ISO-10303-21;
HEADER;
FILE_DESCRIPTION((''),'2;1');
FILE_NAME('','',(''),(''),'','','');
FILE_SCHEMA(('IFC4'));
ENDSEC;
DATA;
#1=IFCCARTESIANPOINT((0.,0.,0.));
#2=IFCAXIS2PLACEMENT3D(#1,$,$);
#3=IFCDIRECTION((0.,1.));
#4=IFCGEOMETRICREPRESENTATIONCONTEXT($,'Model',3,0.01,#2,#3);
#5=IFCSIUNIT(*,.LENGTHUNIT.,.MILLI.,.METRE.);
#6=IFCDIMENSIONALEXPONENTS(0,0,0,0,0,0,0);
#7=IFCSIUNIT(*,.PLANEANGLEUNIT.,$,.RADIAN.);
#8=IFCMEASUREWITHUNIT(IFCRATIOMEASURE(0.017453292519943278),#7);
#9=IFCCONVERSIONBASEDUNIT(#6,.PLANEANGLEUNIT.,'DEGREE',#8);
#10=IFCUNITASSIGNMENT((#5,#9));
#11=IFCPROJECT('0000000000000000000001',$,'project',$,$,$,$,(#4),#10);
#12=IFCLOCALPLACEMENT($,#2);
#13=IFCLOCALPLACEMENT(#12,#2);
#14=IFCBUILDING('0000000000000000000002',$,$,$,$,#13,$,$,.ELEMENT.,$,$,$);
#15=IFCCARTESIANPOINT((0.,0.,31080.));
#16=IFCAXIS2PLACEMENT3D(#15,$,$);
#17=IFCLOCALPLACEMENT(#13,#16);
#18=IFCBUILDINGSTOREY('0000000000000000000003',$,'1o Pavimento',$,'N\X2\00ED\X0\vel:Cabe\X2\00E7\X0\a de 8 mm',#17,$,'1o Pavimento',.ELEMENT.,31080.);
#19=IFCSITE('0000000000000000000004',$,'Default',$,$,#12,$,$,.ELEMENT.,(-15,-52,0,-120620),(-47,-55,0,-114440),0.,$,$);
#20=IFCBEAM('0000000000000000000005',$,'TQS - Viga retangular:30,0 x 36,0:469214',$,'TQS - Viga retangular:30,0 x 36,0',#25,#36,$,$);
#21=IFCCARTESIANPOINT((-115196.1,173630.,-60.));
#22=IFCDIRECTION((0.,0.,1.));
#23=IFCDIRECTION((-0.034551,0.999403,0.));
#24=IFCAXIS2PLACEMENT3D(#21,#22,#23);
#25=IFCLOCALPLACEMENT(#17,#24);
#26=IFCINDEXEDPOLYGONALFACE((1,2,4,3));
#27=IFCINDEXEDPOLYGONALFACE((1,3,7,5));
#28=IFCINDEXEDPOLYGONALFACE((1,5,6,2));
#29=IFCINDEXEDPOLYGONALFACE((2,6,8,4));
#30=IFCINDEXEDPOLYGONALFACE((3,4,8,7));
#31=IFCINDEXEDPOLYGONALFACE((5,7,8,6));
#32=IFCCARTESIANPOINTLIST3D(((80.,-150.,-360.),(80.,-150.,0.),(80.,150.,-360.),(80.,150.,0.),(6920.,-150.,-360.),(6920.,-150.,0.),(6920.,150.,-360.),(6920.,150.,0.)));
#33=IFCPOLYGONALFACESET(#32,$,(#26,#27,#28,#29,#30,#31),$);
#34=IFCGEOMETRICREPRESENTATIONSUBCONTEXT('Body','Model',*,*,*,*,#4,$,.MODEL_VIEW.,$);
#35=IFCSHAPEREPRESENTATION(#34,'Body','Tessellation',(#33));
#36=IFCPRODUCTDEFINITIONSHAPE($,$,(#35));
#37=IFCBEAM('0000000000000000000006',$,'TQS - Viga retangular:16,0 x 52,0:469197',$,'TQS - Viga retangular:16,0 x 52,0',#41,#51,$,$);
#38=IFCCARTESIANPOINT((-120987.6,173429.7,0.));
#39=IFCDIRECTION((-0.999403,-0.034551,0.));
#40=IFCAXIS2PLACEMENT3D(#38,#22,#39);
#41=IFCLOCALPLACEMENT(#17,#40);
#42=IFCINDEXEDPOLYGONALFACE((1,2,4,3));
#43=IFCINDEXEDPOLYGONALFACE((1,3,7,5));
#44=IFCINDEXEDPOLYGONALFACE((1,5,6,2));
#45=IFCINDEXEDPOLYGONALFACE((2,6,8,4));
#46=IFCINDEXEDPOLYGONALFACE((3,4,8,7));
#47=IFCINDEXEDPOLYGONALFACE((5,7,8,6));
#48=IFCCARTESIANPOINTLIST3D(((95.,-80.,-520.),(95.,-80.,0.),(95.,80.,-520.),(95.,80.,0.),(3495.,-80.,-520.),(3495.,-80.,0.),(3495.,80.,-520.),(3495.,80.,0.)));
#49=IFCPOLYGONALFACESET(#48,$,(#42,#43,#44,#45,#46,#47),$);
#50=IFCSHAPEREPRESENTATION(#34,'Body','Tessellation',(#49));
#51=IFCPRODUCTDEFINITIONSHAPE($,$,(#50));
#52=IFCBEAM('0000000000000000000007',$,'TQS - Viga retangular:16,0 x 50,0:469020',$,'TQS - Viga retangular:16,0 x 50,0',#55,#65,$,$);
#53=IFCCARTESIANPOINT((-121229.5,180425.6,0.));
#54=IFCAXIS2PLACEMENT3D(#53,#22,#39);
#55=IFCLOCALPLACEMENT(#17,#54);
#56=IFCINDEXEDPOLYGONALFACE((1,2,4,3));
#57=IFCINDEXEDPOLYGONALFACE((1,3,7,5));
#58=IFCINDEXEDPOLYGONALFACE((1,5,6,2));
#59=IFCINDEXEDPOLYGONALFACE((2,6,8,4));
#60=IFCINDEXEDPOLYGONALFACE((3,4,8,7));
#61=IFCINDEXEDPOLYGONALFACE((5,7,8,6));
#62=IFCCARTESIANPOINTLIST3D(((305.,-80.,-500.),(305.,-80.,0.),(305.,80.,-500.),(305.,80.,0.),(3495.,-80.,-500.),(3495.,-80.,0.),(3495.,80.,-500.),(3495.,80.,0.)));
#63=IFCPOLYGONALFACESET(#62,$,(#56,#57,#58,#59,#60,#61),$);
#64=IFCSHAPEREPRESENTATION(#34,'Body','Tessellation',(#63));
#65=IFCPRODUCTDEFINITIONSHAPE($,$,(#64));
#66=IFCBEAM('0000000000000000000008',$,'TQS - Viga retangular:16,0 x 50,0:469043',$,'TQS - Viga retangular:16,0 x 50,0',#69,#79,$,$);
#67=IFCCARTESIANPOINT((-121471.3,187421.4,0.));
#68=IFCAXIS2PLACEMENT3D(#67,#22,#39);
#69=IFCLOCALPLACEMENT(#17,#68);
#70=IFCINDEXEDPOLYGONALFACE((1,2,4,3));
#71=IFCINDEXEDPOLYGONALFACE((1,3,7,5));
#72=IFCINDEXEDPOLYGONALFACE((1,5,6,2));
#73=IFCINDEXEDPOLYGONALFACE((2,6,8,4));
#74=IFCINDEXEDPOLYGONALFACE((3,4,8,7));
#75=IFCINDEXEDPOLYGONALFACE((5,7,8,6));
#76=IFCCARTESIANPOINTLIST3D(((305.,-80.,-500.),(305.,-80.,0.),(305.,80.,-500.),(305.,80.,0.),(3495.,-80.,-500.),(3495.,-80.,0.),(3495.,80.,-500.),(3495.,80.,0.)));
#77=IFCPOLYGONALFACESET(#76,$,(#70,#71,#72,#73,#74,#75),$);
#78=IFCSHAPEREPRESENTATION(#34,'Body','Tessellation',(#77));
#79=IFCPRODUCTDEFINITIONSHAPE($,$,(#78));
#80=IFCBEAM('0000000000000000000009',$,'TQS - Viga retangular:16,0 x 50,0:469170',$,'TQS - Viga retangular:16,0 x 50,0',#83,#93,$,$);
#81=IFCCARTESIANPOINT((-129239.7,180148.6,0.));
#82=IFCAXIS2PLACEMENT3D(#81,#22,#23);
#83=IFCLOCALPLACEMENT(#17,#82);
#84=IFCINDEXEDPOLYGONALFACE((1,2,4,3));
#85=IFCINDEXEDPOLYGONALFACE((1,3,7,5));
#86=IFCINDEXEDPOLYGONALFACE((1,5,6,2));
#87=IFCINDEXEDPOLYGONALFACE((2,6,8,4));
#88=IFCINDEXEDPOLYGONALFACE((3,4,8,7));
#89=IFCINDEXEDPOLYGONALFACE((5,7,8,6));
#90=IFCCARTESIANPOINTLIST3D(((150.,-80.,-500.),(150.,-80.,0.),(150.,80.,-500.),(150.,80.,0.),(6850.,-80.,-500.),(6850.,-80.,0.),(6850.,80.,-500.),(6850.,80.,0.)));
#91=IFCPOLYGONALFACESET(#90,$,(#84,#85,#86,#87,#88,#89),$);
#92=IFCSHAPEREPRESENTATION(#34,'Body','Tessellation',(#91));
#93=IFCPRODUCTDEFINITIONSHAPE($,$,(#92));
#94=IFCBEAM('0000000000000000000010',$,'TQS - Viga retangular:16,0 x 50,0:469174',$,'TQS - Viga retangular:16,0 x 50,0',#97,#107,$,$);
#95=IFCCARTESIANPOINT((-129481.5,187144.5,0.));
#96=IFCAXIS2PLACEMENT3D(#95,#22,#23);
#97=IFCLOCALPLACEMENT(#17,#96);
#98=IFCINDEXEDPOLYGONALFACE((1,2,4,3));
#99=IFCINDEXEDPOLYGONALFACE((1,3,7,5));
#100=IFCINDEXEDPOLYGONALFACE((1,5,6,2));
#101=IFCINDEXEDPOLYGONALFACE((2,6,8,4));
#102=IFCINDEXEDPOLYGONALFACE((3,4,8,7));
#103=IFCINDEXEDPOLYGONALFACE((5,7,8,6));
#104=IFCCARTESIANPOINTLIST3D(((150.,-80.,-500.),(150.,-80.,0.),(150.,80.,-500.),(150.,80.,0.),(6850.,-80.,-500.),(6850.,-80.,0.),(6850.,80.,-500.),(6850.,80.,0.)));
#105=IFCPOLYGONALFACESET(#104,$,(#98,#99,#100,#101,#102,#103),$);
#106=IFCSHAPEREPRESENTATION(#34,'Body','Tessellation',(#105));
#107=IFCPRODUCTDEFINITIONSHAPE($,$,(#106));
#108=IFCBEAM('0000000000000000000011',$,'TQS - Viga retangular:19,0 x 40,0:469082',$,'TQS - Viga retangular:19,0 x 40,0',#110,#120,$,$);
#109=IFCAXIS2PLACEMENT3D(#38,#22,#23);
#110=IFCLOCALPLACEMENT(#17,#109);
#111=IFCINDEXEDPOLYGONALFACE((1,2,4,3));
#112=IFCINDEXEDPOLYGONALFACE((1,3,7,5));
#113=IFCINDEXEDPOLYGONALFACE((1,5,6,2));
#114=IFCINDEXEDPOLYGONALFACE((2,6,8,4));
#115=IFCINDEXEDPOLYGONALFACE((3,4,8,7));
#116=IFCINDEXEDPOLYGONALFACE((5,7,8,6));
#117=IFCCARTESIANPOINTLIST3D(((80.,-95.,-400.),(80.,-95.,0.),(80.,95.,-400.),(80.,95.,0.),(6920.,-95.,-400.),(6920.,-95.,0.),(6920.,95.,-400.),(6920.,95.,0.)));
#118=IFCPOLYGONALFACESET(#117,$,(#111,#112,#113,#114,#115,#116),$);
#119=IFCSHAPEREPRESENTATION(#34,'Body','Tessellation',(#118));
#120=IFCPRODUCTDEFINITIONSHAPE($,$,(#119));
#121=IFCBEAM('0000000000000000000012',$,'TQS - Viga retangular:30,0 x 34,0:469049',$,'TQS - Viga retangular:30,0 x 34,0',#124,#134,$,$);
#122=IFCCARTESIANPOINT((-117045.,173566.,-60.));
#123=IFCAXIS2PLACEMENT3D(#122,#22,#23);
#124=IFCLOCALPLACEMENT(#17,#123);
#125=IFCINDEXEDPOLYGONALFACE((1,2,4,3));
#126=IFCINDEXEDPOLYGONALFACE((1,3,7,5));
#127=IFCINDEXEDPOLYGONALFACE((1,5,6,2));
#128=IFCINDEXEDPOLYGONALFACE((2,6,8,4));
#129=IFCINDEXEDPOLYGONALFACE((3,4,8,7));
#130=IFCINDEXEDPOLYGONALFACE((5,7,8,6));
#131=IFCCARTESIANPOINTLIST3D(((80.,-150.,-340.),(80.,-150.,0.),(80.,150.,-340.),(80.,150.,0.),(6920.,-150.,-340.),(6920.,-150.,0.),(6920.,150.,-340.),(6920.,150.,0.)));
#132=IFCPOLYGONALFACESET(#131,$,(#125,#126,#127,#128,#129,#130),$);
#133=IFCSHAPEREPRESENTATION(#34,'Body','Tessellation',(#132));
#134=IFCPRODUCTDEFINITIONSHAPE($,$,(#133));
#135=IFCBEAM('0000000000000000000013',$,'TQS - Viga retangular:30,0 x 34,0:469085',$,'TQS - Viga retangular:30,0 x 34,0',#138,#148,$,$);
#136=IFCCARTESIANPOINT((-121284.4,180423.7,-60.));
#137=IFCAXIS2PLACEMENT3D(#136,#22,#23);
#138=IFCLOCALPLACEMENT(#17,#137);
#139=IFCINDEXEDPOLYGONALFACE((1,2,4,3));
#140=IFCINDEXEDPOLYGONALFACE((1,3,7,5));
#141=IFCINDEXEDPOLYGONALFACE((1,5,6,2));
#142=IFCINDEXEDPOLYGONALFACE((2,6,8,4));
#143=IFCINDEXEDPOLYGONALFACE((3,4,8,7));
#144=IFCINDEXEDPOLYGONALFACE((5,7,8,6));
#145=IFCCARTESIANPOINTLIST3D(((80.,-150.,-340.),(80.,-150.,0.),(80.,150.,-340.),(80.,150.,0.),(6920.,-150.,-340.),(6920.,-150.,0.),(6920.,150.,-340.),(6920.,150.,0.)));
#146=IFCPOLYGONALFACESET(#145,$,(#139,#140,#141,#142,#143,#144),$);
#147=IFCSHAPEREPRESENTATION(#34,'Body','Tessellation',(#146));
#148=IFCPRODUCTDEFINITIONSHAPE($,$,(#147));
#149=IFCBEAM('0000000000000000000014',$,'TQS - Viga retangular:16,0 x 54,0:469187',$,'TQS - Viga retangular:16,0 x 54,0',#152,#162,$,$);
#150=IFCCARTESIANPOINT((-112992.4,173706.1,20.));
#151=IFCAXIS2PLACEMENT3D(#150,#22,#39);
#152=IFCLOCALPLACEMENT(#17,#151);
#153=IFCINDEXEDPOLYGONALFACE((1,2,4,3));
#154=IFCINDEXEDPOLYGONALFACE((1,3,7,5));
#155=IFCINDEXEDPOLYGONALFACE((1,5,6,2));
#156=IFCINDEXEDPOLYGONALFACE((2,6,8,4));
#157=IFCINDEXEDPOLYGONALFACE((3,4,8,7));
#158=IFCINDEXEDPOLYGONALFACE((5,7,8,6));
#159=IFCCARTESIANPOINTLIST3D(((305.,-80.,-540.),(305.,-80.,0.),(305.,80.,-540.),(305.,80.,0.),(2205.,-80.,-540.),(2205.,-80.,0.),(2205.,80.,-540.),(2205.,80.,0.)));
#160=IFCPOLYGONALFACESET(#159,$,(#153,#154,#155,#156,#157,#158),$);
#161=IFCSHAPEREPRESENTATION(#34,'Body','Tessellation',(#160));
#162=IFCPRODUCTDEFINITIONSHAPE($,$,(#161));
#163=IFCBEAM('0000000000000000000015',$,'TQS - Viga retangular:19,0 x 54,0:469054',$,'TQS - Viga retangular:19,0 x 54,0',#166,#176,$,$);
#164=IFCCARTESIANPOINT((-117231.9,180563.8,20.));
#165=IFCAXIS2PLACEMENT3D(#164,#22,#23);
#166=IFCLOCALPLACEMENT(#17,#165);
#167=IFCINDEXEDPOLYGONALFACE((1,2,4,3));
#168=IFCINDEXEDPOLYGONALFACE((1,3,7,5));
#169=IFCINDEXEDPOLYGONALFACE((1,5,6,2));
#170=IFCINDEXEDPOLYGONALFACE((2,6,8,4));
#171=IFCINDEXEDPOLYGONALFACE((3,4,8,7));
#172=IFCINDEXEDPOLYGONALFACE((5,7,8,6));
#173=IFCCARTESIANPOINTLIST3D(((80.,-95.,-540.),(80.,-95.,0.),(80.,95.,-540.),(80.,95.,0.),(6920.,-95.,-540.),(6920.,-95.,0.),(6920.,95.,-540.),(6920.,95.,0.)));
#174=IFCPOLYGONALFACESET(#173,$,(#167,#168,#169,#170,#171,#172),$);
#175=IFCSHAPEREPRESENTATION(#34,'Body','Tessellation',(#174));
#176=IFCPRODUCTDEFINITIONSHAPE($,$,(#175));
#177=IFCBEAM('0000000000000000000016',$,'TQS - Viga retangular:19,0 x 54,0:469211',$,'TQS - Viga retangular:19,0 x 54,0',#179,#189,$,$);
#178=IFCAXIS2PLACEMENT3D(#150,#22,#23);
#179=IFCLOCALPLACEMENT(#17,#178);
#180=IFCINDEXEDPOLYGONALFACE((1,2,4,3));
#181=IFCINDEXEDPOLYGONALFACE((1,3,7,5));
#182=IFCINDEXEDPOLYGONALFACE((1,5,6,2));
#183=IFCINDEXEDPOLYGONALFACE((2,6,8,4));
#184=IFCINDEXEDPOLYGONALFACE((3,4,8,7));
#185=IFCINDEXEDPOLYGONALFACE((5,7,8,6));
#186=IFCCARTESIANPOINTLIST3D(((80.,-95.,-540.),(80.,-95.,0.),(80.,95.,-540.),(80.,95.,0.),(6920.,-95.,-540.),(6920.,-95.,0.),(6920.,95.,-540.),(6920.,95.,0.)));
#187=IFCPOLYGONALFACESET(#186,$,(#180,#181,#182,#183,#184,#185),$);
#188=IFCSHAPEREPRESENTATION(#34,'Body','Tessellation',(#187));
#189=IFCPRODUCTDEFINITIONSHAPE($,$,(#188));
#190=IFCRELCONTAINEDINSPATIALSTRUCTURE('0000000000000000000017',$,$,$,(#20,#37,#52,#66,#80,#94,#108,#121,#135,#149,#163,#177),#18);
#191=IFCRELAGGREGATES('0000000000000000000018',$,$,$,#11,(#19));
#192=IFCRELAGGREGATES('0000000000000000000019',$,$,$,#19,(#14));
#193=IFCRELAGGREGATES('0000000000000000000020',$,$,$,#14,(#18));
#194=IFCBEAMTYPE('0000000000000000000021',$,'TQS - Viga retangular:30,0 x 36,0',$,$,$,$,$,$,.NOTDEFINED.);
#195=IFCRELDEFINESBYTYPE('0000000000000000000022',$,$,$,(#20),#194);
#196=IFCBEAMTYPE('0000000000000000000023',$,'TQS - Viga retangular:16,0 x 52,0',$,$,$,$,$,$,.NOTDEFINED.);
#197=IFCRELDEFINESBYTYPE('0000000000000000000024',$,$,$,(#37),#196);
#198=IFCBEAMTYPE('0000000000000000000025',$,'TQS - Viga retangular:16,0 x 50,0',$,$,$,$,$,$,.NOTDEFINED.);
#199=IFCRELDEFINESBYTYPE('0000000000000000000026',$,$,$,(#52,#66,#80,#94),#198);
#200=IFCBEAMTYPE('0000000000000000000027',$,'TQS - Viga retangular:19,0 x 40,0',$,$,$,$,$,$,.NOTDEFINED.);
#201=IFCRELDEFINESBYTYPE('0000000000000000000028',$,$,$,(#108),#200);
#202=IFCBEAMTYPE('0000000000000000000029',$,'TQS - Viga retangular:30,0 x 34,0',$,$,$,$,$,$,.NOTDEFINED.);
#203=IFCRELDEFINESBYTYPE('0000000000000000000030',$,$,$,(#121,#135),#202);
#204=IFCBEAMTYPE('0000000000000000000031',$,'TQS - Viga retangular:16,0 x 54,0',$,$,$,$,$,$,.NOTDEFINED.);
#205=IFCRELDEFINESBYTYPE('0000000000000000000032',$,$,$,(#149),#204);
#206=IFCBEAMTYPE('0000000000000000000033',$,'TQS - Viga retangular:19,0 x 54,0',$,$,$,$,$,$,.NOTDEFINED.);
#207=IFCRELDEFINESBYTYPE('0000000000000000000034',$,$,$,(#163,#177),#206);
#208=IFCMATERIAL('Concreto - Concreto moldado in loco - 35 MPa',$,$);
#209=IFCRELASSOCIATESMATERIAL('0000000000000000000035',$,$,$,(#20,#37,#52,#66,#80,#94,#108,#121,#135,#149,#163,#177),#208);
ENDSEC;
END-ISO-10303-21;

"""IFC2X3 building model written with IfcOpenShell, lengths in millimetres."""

from ifc_helpers import new_model, entity, si_unit, converted_unit, direction, frame, frame_2d, origin, place, context, subcontext, project, spatial, rectangle, extrude, material, type_object, element, save


model = new_model("IFC2X3")

# Units and contexts
model_context = context("Model", 3, precision=0.01, world=origin(), true_north=direction((0.0, 1.0)))
body_context = subcontext(model_context, "Body", "Model", "MODEL_VIEW")
ifc_project = project(units=[si_unit("LENGTHUNIT", "METRE", prefix="MILLI"), converted_unit("PLANEANGLEUNIT", "DEGREE", entity("IfcRatioMeasure", 0.017453292519943278), si_unit("PLANEANGLEUNIT", "RADIAN"), dimensions=[0, 0, 0, 0, 0, 0, 0])], contexts=[model_context])

# Site, building, storey
site_placement = place(None, origin())
site = spatial("IfcSite", under=ifc_project, at=site_placement, Name="Default", CompositionType="ELEMENT", RefLatitude=(-15, -52, 0, -120620), RefLongitude=(-47, -55, 0, -114440), RefElevation=0.0)
building_placement = place(site_placement, origin())
building = spatial("IfcBuilding", under=site, at=building_placement, CompositionType="ELEMENT")
storey_placement = place(building_placement, frame((0.0, 0.0, 31080.0)))
storey = spatial("IfcBuildingStorey", under=building, at=storey_placement, Name="1o Pavimento", ObjectType="Nível:Cabeça de 8 mm", LongName="1o Pavimento", CompositionType="ELEMENT", Elevation=31080.0)

# Beams
ifc_material_1 = material(Name="Concreto - Concreto moldado in loco - 35 MPa")
beam_type_1 = type_object("IfcBeamType", Name="TQS - Viga retangular:30,0 x 36,0", PredefinedType="NOTDEFINED")
beam_1_placement = place(storey_placement, frame((-115196.1, 173630.0, -60.0), z_axis=(0.0, 0.0, 1.0), x_axis=(-0.034551, 0.999403, 0.0)))
element("IfcBeam", 1, at=beam_1_placement, inside=storey, type_object=beam_type_1, material=ifc_material_1, Name="TQS - Viga retangular:30,0 x 36,0:469214", ObjectType="TQS - Viga retangular:30,0 x 36,0", context=body_context, shape_type="SweptSolid", body=[
    extrude(rectangle(XDim=360.0, YDim=300.0, at=frame_2d((0.0, 0.0), x_axis=(1.0, 0.0))), frame((80.0, 0.0, -180.0), z_axis=(1.0, 0.0, 0.0), x_axis=(0.0, 0.0, -1.0)), (0.0, 0.0, 1.0), 6840.0),
])
beam_type_2 = type_object("IfcBeamType", Name="TQS - Viga retangular:16,0 x 52,0", PredefinedType="NOTDEFINED")
beam_2_placement = place(storey_placement, frame((-120987.6, 173429.7, 0.0), z_axis=(0.0, 0.0, 1.0), x_axis=(-0.999403, -0.034551, 0.0)))
element("IfcBeam", 2, at=beam_2_placement, inside=storey, type_object=beam_type_2, material=ifc_material_1, Name="TQS - Viga retangular:16,0 x 52,0:469197", ObjectType="TQS - Viga retangular:16,0 x 52,0", context=body_context, shape_type="SweptSolid", body=[
    extrude(rectangle(XDim=520.0, YDim=160.0, at=frame_2d((0.0, 0.0), x_axis=(1.0, 0.0))), frame((95.0, 0.0, -260.0), z_axis=(1.0, 0.0, 0.0), x_axis=(0.0, 0.0, -1.0)), (0.0, 0.0, 1.0), 3400.0),
])
beam_type_3 = type_object("IfcBeamType", Name="TQS - Viga retangular:16,0 x 50,0", PredefinedType="NOTDEFINED")
beam_3_placement = place(storey_placement, frame((-121229.5, 180425.6, 0.0), z_axis=(0.0, 0.0, 1.0), x_axis=(-0.999403, -0.034551, 0.0)))
element("IfcBeam", 3, at=beam_3_placement, inside=storey, type_object=beam_type_3, material=ifc_material_1, Name="TQS - Viga retangular:16,0 x 50,0:469020", ObjectType="TQS - Viga retangular:16,0 x 50,0", context=body_context, shape_type="SweptSolid", body=[
    extrude(rectangle(XDim=500.0, YDim=160.0, at=frame_2d((0.0, 0.0), x_axis=(1.0, 0.0))), frame((305.0, 0.0, -250.0), z_axis=(1.0, 0.0, 0.0), x_axis=(0.0, 0.0, -1.0)), (0.0, 0.0, 1.0), 3190.0),
])
beam_4_placement = place(storey_placement, frame((-121471.3, 187421.4, 0.0), z_axis=(0.0, 0.0, 1.0), x_axis=(-0.999403, -0.034551, 0.0)))
element("IfcBeam", 4, at=beam_4_placement, inside=storey, type_object=beam_type_3, material=ifc_material_1, Name="TQS - Viga retangular:16,0 x 50,0:469043", ObjectType="TQS - Viga retangular:16,0 x 50,0", context=body_context, shape_type="SweptSolid", body=[
    extrude(rectangle(XDim=500.0, YDim=160.0, at=frame_2d((0.0, 0.0), x_axis=(1.0, 0.0))), frame((305.0, 0.0, -250.0), z_axis=(1.0, 0.0, 0.0), x_axis=(0.0, 0.0, -1.0)), (0.0, 0.0, 1.0), 3190.0),
])
beam_5_placement = place(storey_placement, frame((-129239.7, 180148.6, 0.0), z_axis=(0.0, 0.0, 1.0), x_axis=(-0.034551, 0.999403, 0.0)))
element("IfcBeam", 5, at=beam_5_placement, inside=storey, type_object=beam_type_3, material=ifc_material_1, Name="TQS - Viga retangular:16,0 x 50,0:469170", ObjectType="TQS - Viga retangular:16,0 x 50,0", context=body_context, shape_type="SweptSolid", body=[
    extrude(rectangle(XDim=500.0, YDim=160.0, at=frame_2d((0.0, 0.0), x_axis=(1.0, 0.0))), frame((150.0, 0.0, -250.0), z_axis=(1.0, 0.0, 0.0), x_axis=(0.0, 0.0, -1.0)), (0.0, 0.0, 1.0), 6700.0),
])
beam_6_placement = place(storey_placement, frame((-129481.5, 187144.5, 0.0), z_axis=(0.0, 0.0, 1.0), x_axis=(-0.034551, 0.999403, 0.0)))
element("IfcBeam", 6, at=beam_6_placement, inside=storey, type_object=beam_type_3, material=ifc_material_1, Name="TQS - Viga retangular:16,0 x 50,0:469174", ObjectType="TQS - Viga retangular:16,0 x 50,0", context=body_context, shape_type="SweptSolid", body=[
    extrude(rectangle(XDim=500.0, YDim=160.0, at=frame_2d((0.0, 0.0), x_axis=(1.0, 0.0))), frame((150.0, 0.0, -250.0), z_axis=(1.0, 0.0, 0.0), x_axis=(0.0, 0.0, -1.0)), (0.0, 0.0, 1.0), 6700.0),
])
beam_type_4 = type_object("IfcBeamType", Name="TQS - Viga retangular:19,0 x 40,0", PredefinedType="NOTDEFINED")
beam_7_placement = place(storey_placement, frame((-120987.6, 173429.7, 0.0), z_axis=(0.0, 0.0, 1.0), x_axis=(-0.034551, 0.999403, 0.0)))
element("IfcBeam", 7, at=beam_7_placement, inside=storey, type_object=beam_type_4, material=ifc_material_1, Name="TQS - Viga retangular:19,0 x 40,0:469082", ObjectType="TQS - Viga retangular:19,0 x 40,0", context=body_context, shape_type="SweptSolid", body=[
    extrude(rectangle(XDim=400.0, YDim=190.0, at=frame_2d((0.0, 0.0), x_axis=(1.0, 0.0))), frame((80.0, 0.0, -200.0), z_axis=(1.0, 0.0, 0.0), x_axis=(0.0, 0.0, -1.0)), (0.0, 0.0, 1.0), 6840.0),
])
beam_type_5 = type_object("IfcBeamType", Name="TQS - Viga retangular:30,0 x 34,0", PredefinedType="NOTDEFINED")
beam_8_placement = place(storey_placement, frame((-117045.0, 173566.0, -60.0), z_axis=(0.0, 0.0, 1.0), x_axis=(-0.034551, 0.999403, 0.0)))
element("IfcBeam", 8, at=beam_8_placement, inside=storey, type_object=beam_type_5, material=ifc_material_1, Name="TQS - Viga retangular:30,0 x 34,0:469049", ObjectType="TQS - Viga retangular:30,0 x 34,0", context=body_context, shape_type="SweptSolid", body=[
    extrude(rectangle(XDim=340.0, YDim=300.0, at=frame_2d((0.0, 0.0), x_axis=(1.0, 0.0))), frame((80.0, 0.0, -170.0), z_axis=(1.0, 0.0, 0.0), x_axis=(0.0, 0.0, -1.0)), (0.0, 0.0, 1.0), 6840.0),
])
beam_9_placement = place(storey_placement, frame((-121284.4, 180423.7, -60.0), z_axis=(0.0, 0.0, 1.0), x_axis=(-0.034551, 0.999403, 0.0)))
element("IfcBeam", 9, at=beam_9_placement, inside=storey, type_object=beam_type_5, material=ifc_material_1, Name="TQS - Viga retangular:30,0 x 34,0:469085", ObjectType="TQS - Viga retangular:30,0 x 34,0", context=body_context, shape_type="SweptSolid", body=[
    extrude(rectangle(XDim=340.0, YDim=300.0, at=frame_2d((0.0, 0.0), x_axis=(1.0, 0.0))), frame((80.0, 0.0, -170.0), z_axis=(1.0, 0.0, 0.0), x_axis=(0.0, 0.0, -1.0)), (0.0, 0.0, 1.0), 6840.0),
])
beam_type_6 = type_object("IfcBeamType", Name="TQS - Viga retangular:16,0 x 54,0", PredefinedType="NOTDEFINED")
beam_10_placement = place(storey_placement, frame((-112992.4, 173706.1, 20.0), z_axis=(0.0, 0.0, 1.0), x_axis=(-0.999403, -0.034551, 0.0)))
element("IfcBeam", 10, at=beam_10_placement, inside=storey, type_object=beam_type_6, material=ifc_material_1, Name="TQS - Viga retangular:16,0 x 54,0:469187", ObjectType="TQS - Viga retangular:16,0 x 54,0", context=body_context, shape_type="SweptSolid", body=[
    extrude(rectangle(XDim=540.0, YDim=160.0, at=frame_2d((0.0, 0.0), x_axis=(1.0, 0.0))), frame((305.0, 0.0, -270.0), z_axis=(1.0, 0.0, 0.0), x_axis=(0.0, 0.0, -1.0)), (0.0, 0.0, 1.0), 1900.0),
])
beam_type_7 = type_object("IfcBeamType", Name="TQS - Viga retangular:19,0 x 54,0", PredefinedType="NOTDEFINED")
beam_11_placement = place(storey_placement, frame((-117231.9, 180563.8, 20.0), z_axis=(0.0, 0.0, 1.0), x_axis=(-0.034551, 0.999403, 0.0)))
element("IfcBeam", 11, at=beam_11_placement, inside=storey, type_object=beam_type_7, material=ifc_material_1, Name="TQS - Viga retangular:19,0 x 54,0:469054", ObjectType="TQS - Viga retangular:19,0 x 54,0", context=body_context, shape_type="SweptSolid", body=[
    extrude(rectangle(XDim=540.0, YDim=190.0, at=frame_2d((0.0, 0.0), x_axis=(1.0, 0.0))), frame((80.0, 0.0, -270.0), z_axis=(1.0, 0.0, 0.0), x_axis=(0.0, 0.0, -1.0)), (0.0, 0.0, 1.0), 6840.0),
])
beam_12_placement = place(storey_placement, frame((-112992.4, 173706.1, 20.0), z_axis=(0.0, 0.0, 1.0), x_axis=(-0.034551, 0.999403, 0.0)))
element("IfcBeam", 12, at=beam_12_placement, inside=storey, type_object=beam_type_7, material=ifc_material_1, Name="TQS - Viga retangular:19,0 x 54,0:469211", ObjectType="TQS - Viga retangular:19,0 x 54,0", context=body_context, shape_type="SweptSolid", body=[
    extrude(rectangle(XDim=540.0, YDim=190.0, at=frame_2d((0.0, 0.0), x_axis=(1.0, 0.0))), frame((80.0, 0.0, -270.0), z_axis=(1.0, 0.0, 0.0), x_axis=(0.0, 0.0, -1.0)), (0.0, 0.0, 1.0), 6840.0),
])

save(model, "model.ifc")
